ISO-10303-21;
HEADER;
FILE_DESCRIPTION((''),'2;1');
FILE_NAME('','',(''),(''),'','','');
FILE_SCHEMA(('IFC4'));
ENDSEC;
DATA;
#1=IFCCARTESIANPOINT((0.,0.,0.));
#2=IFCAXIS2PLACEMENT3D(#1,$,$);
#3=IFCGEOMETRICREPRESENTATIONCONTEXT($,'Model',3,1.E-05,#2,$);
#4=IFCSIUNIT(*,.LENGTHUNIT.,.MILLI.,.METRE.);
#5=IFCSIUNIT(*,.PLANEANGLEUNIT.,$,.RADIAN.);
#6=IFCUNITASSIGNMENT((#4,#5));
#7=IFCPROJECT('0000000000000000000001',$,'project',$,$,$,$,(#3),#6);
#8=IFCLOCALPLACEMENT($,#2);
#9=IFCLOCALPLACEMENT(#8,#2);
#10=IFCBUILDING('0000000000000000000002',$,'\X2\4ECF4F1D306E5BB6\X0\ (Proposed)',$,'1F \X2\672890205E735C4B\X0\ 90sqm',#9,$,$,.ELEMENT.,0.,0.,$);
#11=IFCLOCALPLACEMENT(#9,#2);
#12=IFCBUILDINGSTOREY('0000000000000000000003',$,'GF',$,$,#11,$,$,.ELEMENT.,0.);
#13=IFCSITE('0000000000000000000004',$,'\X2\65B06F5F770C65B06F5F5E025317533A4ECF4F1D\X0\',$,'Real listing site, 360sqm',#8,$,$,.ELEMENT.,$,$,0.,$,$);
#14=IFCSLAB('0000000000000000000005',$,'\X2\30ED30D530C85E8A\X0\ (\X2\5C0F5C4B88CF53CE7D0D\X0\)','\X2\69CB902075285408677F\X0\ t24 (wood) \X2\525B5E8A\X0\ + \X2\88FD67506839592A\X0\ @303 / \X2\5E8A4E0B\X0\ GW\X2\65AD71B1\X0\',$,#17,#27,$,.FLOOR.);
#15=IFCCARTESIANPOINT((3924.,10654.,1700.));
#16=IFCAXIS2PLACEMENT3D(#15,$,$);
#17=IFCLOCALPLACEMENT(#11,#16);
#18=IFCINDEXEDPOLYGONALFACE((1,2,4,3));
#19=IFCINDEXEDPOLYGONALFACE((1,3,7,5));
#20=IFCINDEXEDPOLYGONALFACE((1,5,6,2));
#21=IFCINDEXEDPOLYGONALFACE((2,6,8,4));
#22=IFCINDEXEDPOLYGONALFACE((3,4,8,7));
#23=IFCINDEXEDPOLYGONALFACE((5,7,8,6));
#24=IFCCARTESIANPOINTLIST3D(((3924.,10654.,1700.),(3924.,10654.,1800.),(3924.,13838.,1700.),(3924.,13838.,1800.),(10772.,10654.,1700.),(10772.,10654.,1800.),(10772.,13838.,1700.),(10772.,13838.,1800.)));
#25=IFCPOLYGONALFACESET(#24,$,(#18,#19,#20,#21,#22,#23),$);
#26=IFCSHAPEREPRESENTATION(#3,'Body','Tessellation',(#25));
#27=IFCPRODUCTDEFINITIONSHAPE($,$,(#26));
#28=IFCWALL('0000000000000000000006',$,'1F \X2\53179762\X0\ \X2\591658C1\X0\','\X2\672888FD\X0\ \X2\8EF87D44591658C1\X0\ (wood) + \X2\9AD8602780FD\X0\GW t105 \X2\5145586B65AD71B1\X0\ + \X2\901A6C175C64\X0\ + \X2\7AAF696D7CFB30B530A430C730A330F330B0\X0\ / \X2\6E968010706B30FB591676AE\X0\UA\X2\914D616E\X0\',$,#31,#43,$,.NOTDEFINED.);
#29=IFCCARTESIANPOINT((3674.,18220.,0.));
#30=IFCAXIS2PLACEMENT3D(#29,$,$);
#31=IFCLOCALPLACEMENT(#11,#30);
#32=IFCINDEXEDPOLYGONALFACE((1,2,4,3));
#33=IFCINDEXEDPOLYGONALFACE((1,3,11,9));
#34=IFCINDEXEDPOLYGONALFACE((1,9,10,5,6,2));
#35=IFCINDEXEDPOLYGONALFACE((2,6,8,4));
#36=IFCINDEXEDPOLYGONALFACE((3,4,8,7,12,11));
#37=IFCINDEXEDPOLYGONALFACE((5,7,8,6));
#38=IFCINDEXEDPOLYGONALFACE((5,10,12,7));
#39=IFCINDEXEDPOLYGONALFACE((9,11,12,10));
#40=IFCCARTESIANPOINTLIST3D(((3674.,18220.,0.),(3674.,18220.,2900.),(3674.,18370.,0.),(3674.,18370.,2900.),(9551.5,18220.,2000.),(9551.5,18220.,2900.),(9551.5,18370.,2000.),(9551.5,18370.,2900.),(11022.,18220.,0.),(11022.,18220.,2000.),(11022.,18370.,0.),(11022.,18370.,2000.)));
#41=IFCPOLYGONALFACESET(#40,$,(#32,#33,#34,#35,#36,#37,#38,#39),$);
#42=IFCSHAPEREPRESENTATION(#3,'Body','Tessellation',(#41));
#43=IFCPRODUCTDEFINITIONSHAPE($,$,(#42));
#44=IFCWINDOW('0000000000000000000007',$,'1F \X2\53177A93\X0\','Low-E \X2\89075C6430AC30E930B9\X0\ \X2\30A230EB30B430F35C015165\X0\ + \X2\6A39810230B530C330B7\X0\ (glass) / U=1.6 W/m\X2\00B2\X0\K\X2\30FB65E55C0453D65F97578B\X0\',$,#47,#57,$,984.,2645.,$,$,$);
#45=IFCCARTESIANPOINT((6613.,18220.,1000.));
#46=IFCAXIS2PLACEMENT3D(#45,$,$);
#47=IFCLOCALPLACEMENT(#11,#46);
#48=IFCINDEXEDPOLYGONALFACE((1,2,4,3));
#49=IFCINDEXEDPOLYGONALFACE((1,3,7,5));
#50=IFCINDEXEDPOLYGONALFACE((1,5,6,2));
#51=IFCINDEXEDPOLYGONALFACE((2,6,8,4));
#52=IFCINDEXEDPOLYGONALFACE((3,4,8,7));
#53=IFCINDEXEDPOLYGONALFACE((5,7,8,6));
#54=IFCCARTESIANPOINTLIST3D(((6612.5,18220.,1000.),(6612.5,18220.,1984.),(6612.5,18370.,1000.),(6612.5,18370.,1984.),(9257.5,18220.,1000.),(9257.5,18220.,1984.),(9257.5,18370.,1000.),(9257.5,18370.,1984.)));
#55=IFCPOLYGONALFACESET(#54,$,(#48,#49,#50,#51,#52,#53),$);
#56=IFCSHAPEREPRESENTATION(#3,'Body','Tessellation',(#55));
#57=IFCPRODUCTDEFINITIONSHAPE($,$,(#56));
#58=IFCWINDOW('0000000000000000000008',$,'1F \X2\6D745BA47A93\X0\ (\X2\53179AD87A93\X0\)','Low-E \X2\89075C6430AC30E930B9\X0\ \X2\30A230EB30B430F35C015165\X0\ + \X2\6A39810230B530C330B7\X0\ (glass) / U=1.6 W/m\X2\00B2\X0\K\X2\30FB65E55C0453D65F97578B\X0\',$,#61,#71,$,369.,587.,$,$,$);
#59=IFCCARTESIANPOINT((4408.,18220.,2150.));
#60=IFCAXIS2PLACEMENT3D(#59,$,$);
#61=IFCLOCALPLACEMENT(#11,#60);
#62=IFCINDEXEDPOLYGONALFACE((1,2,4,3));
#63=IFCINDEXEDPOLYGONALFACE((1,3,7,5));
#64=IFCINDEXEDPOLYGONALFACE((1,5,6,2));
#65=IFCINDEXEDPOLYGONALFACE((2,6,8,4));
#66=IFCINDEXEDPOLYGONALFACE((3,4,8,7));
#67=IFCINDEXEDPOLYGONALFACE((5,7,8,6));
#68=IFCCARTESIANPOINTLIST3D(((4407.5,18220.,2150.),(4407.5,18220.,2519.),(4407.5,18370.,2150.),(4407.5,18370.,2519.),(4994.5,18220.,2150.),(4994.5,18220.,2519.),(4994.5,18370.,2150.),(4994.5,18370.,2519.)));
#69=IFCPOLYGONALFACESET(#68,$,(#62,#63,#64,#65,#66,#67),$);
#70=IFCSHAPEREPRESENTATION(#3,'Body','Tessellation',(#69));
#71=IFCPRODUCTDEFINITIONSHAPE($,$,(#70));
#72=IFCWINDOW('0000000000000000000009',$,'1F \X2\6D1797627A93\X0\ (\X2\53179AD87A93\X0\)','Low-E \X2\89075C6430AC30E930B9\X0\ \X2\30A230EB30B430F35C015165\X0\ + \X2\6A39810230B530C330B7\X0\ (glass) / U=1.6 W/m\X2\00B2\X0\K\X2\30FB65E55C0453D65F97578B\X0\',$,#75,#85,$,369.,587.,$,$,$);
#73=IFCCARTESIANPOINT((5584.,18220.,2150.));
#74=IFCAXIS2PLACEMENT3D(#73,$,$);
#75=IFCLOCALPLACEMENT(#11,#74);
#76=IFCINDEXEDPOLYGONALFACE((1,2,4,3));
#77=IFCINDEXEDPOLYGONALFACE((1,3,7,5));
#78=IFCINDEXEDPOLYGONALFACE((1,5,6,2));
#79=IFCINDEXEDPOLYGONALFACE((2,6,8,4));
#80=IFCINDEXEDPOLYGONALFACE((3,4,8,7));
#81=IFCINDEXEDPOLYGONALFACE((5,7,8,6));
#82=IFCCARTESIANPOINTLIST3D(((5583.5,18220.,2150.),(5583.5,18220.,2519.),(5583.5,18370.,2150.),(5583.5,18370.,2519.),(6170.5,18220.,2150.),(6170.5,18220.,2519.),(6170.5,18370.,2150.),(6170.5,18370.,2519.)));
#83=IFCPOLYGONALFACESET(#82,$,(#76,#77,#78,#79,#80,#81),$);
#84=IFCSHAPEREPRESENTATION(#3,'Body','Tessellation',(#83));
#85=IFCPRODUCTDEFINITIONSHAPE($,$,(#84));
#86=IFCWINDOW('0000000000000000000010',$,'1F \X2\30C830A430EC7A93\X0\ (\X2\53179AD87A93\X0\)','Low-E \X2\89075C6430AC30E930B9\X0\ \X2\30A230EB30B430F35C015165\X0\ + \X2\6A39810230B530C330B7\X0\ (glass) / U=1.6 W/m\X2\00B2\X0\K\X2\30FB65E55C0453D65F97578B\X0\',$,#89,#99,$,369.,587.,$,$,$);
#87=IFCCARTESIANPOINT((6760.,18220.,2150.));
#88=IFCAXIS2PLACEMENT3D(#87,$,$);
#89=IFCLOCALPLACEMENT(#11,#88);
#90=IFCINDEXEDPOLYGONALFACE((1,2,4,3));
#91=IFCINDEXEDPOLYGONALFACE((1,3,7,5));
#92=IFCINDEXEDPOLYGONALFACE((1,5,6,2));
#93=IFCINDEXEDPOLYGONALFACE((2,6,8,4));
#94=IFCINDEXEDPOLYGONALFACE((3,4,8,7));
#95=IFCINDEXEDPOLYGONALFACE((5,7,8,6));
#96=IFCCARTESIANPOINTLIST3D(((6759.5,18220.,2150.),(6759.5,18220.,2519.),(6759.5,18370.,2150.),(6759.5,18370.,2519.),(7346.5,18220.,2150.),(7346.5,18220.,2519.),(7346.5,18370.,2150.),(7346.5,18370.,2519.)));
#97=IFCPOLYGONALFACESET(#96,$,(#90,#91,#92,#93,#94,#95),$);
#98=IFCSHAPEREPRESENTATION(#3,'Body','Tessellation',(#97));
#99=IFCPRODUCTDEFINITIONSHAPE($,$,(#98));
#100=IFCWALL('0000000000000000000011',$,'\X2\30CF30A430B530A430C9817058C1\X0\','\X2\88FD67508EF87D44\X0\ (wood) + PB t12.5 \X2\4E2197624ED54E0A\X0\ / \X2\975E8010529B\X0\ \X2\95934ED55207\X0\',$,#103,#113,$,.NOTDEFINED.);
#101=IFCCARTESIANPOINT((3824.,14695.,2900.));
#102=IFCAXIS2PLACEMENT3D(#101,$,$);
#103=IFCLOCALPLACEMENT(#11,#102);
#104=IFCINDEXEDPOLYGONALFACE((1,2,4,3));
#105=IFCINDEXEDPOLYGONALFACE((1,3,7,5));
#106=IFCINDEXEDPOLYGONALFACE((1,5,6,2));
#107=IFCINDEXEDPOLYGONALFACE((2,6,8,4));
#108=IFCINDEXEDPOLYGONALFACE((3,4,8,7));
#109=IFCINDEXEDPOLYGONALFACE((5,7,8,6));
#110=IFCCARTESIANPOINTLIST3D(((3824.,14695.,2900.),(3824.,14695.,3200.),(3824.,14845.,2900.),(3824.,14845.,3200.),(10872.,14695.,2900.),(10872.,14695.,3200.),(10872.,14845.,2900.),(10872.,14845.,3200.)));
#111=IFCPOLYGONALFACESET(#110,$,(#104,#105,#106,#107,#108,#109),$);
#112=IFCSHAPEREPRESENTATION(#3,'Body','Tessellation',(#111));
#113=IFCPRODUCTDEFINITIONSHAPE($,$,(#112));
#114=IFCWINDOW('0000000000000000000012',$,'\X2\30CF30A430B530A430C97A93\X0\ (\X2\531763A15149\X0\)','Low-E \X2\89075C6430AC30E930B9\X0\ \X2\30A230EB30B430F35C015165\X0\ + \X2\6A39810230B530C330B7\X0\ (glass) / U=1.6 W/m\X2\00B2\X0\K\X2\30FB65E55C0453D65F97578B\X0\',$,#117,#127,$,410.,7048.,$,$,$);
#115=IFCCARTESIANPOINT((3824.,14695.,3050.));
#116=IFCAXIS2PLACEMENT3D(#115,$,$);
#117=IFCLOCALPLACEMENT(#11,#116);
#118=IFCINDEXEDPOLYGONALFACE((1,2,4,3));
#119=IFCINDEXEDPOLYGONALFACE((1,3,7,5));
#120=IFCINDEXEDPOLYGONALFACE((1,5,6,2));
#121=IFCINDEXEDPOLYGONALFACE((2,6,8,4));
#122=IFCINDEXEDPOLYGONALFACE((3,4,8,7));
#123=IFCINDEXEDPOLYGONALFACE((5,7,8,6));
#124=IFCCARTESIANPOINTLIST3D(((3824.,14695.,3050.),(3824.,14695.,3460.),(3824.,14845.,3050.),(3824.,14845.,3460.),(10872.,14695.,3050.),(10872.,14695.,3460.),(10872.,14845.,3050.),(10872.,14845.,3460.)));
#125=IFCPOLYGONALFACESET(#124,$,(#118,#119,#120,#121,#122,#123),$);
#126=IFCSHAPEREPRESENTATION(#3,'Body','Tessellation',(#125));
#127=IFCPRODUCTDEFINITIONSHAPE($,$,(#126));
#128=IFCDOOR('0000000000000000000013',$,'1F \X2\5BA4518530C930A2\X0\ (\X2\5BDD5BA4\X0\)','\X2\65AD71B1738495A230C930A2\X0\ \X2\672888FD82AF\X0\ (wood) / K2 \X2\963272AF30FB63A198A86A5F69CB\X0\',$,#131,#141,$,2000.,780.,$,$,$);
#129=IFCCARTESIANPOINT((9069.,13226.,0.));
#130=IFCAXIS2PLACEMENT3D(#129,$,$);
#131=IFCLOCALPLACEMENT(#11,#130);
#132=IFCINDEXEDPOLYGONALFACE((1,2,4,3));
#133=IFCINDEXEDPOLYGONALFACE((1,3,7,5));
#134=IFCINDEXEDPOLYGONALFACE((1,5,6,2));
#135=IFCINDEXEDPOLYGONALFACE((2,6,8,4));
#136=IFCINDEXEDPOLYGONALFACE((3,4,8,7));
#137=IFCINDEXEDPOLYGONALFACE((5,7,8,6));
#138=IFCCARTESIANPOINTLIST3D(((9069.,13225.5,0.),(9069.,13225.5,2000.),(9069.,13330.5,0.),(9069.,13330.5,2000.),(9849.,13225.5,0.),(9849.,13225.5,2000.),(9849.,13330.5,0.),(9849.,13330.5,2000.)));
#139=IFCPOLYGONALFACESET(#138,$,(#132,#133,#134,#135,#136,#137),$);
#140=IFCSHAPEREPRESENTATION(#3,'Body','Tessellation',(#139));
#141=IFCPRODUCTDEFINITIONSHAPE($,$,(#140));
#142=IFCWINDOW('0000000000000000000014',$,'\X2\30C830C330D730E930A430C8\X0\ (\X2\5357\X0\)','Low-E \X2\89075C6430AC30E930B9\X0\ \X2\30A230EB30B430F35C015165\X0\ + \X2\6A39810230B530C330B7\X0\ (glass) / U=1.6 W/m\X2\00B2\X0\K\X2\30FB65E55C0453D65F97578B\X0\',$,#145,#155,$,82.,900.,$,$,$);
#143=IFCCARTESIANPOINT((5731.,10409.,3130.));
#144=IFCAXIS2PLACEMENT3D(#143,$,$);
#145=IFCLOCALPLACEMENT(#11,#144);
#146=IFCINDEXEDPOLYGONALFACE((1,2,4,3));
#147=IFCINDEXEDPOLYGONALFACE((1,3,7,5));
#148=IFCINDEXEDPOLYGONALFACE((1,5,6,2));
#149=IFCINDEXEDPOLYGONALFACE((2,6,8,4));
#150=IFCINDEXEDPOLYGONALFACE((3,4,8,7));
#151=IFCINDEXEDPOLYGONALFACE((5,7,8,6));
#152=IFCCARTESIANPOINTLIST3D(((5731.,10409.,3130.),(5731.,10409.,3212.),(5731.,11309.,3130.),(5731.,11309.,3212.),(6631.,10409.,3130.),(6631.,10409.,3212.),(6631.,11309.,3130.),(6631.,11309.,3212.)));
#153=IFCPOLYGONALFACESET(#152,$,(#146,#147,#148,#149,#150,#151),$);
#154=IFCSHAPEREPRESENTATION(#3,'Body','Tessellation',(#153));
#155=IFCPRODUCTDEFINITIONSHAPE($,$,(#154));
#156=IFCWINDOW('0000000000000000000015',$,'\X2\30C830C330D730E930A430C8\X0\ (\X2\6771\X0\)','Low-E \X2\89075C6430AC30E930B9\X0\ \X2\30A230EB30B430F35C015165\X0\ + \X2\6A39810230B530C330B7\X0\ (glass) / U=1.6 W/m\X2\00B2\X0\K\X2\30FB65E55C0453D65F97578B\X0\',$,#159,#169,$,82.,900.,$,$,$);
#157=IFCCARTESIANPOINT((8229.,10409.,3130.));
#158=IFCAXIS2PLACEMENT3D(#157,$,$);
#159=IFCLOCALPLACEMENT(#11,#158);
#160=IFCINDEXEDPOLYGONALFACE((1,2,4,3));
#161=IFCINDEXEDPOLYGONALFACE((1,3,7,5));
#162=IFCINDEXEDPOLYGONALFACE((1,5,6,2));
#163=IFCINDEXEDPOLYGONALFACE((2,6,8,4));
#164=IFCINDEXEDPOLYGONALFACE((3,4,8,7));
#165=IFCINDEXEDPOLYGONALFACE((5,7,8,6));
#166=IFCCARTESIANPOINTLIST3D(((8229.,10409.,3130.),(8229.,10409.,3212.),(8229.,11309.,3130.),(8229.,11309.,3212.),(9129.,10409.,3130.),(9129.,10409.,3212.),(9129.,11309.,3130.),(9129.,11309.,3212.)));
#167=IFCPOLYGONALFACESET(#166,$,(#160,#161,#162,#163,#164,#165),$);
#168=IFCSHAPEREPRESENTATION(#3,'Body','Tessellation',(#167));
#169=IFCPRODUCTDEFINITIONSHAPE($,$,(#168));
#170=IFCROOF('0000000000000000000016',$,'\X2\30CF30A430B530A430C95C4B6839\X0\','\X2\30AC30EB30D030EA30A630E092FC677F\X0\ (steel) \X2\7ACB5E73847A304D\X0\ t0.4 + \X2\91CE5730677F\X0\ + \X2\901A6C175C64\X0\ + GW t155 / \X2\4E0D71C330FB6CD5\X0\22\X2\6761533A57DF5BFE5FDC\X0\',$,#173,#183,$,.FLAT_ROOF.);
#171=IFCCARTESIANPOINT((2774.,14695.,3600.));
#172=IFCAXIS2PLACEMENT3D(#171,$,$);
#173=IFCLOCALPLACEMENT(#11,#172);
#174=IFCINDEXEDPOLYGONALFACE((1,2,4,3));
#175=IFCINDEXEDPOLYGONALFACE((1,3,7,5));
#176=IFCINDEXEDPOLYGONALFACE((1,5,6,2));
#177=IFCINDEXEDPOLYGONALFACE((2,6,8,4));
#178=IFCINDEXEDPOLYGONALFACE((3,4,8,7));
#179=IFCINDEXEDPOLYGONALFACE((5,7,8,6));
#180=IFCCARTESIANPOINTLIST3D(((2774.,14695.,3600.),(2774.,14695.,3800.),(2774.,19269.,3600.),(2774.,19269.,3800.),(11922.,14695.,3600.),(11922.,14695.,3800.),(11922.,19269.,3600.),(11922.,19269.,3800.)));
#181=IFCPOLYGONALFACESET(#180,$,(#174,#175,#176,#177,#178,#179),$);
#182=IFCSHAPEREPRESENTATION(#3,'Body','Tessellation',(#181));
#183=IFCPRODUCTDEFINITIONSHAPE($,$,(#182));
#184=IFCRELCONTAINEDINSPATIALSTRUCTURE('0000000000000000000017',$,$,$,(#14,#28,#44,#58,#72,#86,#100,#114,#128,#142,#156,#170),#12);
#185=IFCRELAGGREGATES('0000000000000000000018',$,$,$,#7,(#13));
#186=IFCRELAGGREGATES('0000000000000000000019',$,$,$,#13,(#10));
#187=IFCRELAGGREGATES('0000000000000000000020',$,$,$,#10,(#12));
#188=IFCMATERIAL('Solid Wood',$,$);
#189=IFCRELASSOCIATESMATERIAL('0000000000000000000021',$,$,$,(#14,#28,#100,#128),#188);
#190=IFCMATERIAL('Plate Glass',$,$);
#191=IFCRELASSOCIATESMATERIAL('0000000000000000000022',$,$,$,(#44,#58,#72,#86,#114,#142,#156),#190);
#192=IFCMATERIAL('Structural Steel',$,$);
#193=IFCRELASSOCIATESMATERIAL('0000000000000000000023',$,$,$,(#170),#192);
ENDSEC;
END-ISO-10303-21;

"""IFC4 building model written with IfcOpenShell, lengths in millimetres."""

from ifc_helpers import new_model, si_unit, frame, frame_2d, origin, place, context, project, spatial, rectangle, extrude, material, element, fill, save


model = new_model("IFC4")

# Units and contexts
model_context = context("Model", 3, precision=1e-05, world=origin())
ifc_project = project(units=[si_unit("LENGTHUNIT", "METRE", prefix="MILLI"), si_unit("PLANEANGLEUNIT", "RADIAN")], contexts=[model_context])

# Site, building, storey
site_placement = place(None, origin())
site = spatial("IfcSite", under=ifc_project, at=site_placement, Name="新潟県新潟市北区仏伝", ObjectType="Real listing site, 360sqm", CompositionType="ELEMENT", RefElevation=0.0)
building_placement = place(site_placement, origin())
building = spatial("IfcBuilding", under=site, at=building_placement, Name="仏伝の家 (Proposed)", ObjectType="1F 木造平屋 90sqm", CompositionType="ELEMENT", ElevationOfRefHeight=0.0, ElevationOfTerrain=0.0)
storey_placement = place(building_placement, origin())
storey = spatial("IfcBuildingStorey", under=building, at=storey_placement, Name="GF", CompositionType="ELEMENT", Elevation=0.0)

# Slab
ifc_material_1 = material(Name="Solid Wood")
slab_placement = place(storey_placement, frame((3924.0, 10654.0, 1700.0)))
element("IfcSlab", 1, at=slab_placement, inside=storey, material=ifc_material_1, Name="ロフト床 (小屋裏収納)", Description="構造用合板 t24 (wood) 剛床 + 製材根太 @303 / 床下 GW断熱", PredefinedType="FLOOR", context=model_context, shape_type="SweptSolid", body=[
    extrude(rectangle(XDim=6848.0, YDim=3184.0, at=frame_2d((3424.0, 1592.0))), frame((3924.0, 10654.0, 1700.0)), (0.0, 0.0, 1.0), 100.0),
])

# Wall, openings, windows
wall_1_placement = place(storey_placement, frame((3674.0, 18220.0, 0.0)))
wall_1 = element("IfcWall", 2, at=wall_1_placement, inside=storey, material=ifc_material_1, Name="1F 北面 外壁", Description="木製 軸組外壁 (wood) + 高性能GW t105 充填断熱 + 通気層 + 窯業系サイディング / 準耐火・外皮UA配慮", PredefinedType="NOTDEFINED", context=model_context, shape_type="SweptSolid", body=[
    extrude(rectangle(XDim=7348.0, YDim=150.0, at=frame_2d((3674.0, 75.0))), frame((3674.0, 18220.0, 0.0)), (0.0, 0.0, 1.0), 2900.0),
])
opening_1_placement = place(storey_placement, frame((6613.0, 18220.0, 1000.0)))
opening_1 = element("IfcOpeningElement", 3, at=opening_1_placement, cuts=wall_1, PredefinedType="NOTDEFINED", context=model_context, shape_type="SweptSolid", body=[
    extrude(rectangle(XDim=2645.0, YDim=150.0, at=frame_2d((1322.0, 75.0))), frame((6613.0, 18220.0, 1000.0)), (0.0, 0.0, 1.0), 984.0),
])
opening_2_placement = place(storey_placement, frame((4408.0, 18220.0, 2150.0)))
opening_2 = element("IfcOpeningElement", 4, at=opening_2_placement, cuts=wall_1, PredefinedType="NOTDEFINED", context=model_context, shape_type="SweptSolid", body=[
    extrude(rectangle(XDim=587.0, YDim=150.0, at=frame_2d((293.0, 75.0))), frame((4408.0, 18220.0, 2150.0)), (0.0, 0.0, 1.0), 369.0),
])
opening_3_placement = place(storey_placement, frame((5584.0, 18220.0, 2150.0)))
opening_3 = element("IfcOpeningElement", 5, at=opening_3_placement, cuts=wall_1, PredefinedType="NOTDEFINED", context=model_context, shape_type="SweptSolid", body=[
    extrude(rectangle(XDim=587.0, YDim=150.0, at=frame_2d((293.0, 75.0))), frame((5584.0, 18220.0, 2150.0)), (0.0, 0.0, 1.0), 369.0),
])
opening_4_placement = place(storey_placement, frame((6760.0, 18220.0, 2150.0)))
opening_4 = element("IfcOpeningElement", 6, at=opening_4_placement, cuts=wall_1, PredefinedType="NOTDEFINED", context=model_context, shape_type="SweptSolid", body=[
    extrude(rectangle(XDim=587.0, YDim=150.0, at=frame_2d((293.0, 75.0))), frame((6760.0, 18220.0, 2150.0)), (0.0, 0.0, 1.0), 369.0),
])
ifc_material_2 = material(Name="Plate Glass")
window_1_placement = place(storey_placement, frame((6613.0, 18220.0, 1000.0)))
window_1 = element("IfcWindow", 7, at=window_1_placement, inside=storey, material=ifc_material_2, Name="1F 北窓", Description="Low-E 複層ガラス アルゴン封入 + 樹脂サッシ (glass) / U=1.6 W/m²K・日射取得型", OverallHeight=984.0, OverallWidth=2645.0, context=model_context, shape_type="SweptSolid", body=[
    extrude(rectangle(XDim=2645.0, YDim=150.0, at=frame_2d((1322.0, 75.0))), frame((6613.0, 18220.0, 1000.0)), (0.0, 0.0, 1.0), 984.0),
])
fill(opening_1, window_1)
window_2_placement = place(storey_placement, frame((4408.0, 18220.0, 2150.0)))
window_2 = element("IfcWindow", 8, at=window_2_placement, inside=storey, material=ifc_material_2, Name="1F 浴室窓 (北高窓)", Description="Low-E 複層ガラス アルゴン封入 + 樹脂サッシ (glass) / U=1.6 W/m²K・日射取得型", OverallHeight=369.0, OverallWidth=587.0, context=model_context, shape_type="SweptSolid", body=[
    extrude(rectangle(XDim=587.0, YDim=150.0, at=frame_2d((293.0, 75.0))), frame((4408.0, 18220.0, 2150.0)), (0.0, 0.0, 1.0), 369.0),
])
fill(opening_2, window_2)
window_3_placement = place(storey_placement, frame((5584.0, 18220.0, 2150.0)))
window_3 = element("IfcWindow", 9, at=window_3_placement, inside=storey, material=ifc_material_2, Name="1F 洗面窓 (北高窓)", Description="Low-E 複層ガラス アルゴン封入 + 樹脂サッシ (glass) / U=1.6 W/m²K・日射取得型", OverallHeight=369.0, OverallWidth=587.0, context=model_context, shape_type="SweptSolid", body=[
    extrude(rectangle(XDim=587.0, YDim=150.0, at=frame_2d((293.0, 75.0))), frame((5584.0, 18220.0, 2150.0)), (0.0, 0.0, 1.0), 369.0),
])
fill(opening_3, window_3)
window_4_placement = place(storey_placement, frame((6760.0, 18220.0, 2150.0)))
window_4 = element("IfcWindow", 10, at=window_4_placement, inside=storey, material=ifc_material_2, Name="1F トイレ窓 (北高窓)", Description="Low-E 複層ガラス アルゴン封入 + 樹脂サッシ (glass) / U=1.6 W/m²K・日射取得型", OverallHeight=369.0, OverallWidth=587.0, context=model_context, shape_type="SweptSolid", body=[
    extrude(rectangle(XDim=587.0, YDim=150.0, at=frame_2d((293.0, 75.0))), frame((6760.0, 18220.0, 2150.0)), (0.0, 0.0, 1.0), 369.0),
])
fill(opening_4, window_4)

# Wall, opening, window
wall_2_placement = place(storey_placement, frame((3824.0, 14695.0, 2900.0)))
wall_2 = element("IfcWall", 11, at=wall_2_placement, inside=storey, material=ifc_material_1, Name="ハイサイド腰壁", Description="製材軸組 (wood) + PB t12.5 両面仕上 / 非耐力 間仕切", PredefinedType="NOTDEFINED", context=model_context, shape_type="SweptSolid", body=[
    extrude(rectangle(XDim=7048.0, YDim=150.0, at=frame_2d((3524.0, 75.0))), frame((3824.0, 14695.0, 2900.0)), (0.0, 0.0, 1.0), 700.0),
])
opening_5_placement = place(storey_placement, frame((3824.0, 14695.0, 3050.0)))
opening_5 = element("IfcOpeningElement", 12, at=opening_5_placement, cuts=wall_2, PredefinedType="NOTDEFINED", context=model_context, shape_type="SweptSolid", body=[
    extrude(rectangle(XDim=7048.0, YDim=150.0, at=frame_2d((3524.0, 75.0))), frame((3824.0, 14695.0, 3050.0)), (0.0, 0.0, 1.0), 410.0),
])
window_5_placement = place(storey_placement, frame((3824.0, 14695.0, 3050.0)))
window_5 = element("IfcWindow", 13, at=window_5_placement, inside=storey, material=ifc_material_2, Name="ハイサイド窓 (北採光)", Description="Low-E 複層ガラス アルゴン封入 + 樹脂サッシ (glass) / U=1.6 W/m²K・日射取得型", OverallHeight=410.0, OverallWidth=7048.0, context=model_context, shape_type="SweptSolid", body=[
    extrude(rectangle(XDim=7048.0, YDim=150.0, at=frame_2d((3524.0, 75.0))), frame((3824.0, 14695.0, 3050.0)), (0.0, 0.0, 1.0), 410.0),
])
fill(opening_5, window_5)

# Door
door_1_placement = place(storey_placement, frame((9069.0, 13226.0, 0.0)))
element("IfcDoor", 14, at=door_1_placement, inside=storey, material=ifc_material_1, Name="1F 室内ドア (寝室)", Description="断熱玄関ドア 木製芯 (wood) / K2 防犯・採風機構", OverallHeight=2000.0, OverallWidth=780.0, context=model_context, shape_type="SweptSolid", body=[
    extrude(rectangle(XDim=780.0, YDim=105.0, at=frame_2d((390.0, 52.0))), frame((9069.0, 13226.0, 0.0)), (0.0, 0.0, 1.0), 2000.0),
])

# Windows
window_6_placement = place(storey_placement, frame((5731.0, 10409.0, 3130.0)))
element("IfcWindow", 15, at=window_6_placement, inside=storey, material=ifc_material_2, Name="トップライト (南)", Description="Low-E 複層ガラス アルゴン封入 + 樹脂サッシ (glass) / U=1.6 W/m²K・日射取得型", OverallHeight=82.0, OverallWidth=900.0, context=model_context, shape_type="SweptSolid", body=[
    extrude(rectangle(XDim=900.0, YDim=900.0, at=frame_2d((450.0, 450.0))), frame((5731.0, 10409.0, 3130.0)), (0.0, 0.0, 1.0), 82.0),
])
window_7_placement = place(storey_placement, frame((8229.0, 10409.0, 3130.0)))
element("IfcWindow", 16, at=window_7_placement, inside=storey, material=ifc_material_2, Name="トップライト (東)", Description="Low-E 複層ガラス アルゴン封入 + 樹脂サッシ (glass) / U=1.6 W/m²K・日射取得型", OverallHeight=82.0, OverallWidth=900.0, context=model_context, shape_type="SweptSolid", body=[
    extrude(rectangle(XDim=900.0, YDim=900.0, at=frame_2d((450.0, 450.0))), frame((8229.0, 10409.0, 3130.0)), (0.0, 0.0, 1.0), 82.0),
])

# Roof
ifc_material_3 = material(Name="Structural Steel")
roof_placement = place(storey_placement, frame((2774.0, 14695.0, 3600.0)))
element("IfcRoof", 17, at=roof_placement, inside=storey, material=ifc_material_3, Name="ハイサイド屋根", Description="ガルバリウム鋼板 (steel) 立平葺き t0.4 + 野地板 + 通気層 + GW t155 / 不燃・法22条区域対応", PredefinedType="FLAT_ROOF", context=model_context, shape_type="SweptSolid", body=[
    extrude(rectangle(XDim=9148.0, YDim=4574.0, at=frame_2d((4574.0, 2287.0))), frame((2774.0, 14695.0, 3600.0)), (0.0, 0.0, 1.0), 200.0),
])

save(model, "model.ifc")
